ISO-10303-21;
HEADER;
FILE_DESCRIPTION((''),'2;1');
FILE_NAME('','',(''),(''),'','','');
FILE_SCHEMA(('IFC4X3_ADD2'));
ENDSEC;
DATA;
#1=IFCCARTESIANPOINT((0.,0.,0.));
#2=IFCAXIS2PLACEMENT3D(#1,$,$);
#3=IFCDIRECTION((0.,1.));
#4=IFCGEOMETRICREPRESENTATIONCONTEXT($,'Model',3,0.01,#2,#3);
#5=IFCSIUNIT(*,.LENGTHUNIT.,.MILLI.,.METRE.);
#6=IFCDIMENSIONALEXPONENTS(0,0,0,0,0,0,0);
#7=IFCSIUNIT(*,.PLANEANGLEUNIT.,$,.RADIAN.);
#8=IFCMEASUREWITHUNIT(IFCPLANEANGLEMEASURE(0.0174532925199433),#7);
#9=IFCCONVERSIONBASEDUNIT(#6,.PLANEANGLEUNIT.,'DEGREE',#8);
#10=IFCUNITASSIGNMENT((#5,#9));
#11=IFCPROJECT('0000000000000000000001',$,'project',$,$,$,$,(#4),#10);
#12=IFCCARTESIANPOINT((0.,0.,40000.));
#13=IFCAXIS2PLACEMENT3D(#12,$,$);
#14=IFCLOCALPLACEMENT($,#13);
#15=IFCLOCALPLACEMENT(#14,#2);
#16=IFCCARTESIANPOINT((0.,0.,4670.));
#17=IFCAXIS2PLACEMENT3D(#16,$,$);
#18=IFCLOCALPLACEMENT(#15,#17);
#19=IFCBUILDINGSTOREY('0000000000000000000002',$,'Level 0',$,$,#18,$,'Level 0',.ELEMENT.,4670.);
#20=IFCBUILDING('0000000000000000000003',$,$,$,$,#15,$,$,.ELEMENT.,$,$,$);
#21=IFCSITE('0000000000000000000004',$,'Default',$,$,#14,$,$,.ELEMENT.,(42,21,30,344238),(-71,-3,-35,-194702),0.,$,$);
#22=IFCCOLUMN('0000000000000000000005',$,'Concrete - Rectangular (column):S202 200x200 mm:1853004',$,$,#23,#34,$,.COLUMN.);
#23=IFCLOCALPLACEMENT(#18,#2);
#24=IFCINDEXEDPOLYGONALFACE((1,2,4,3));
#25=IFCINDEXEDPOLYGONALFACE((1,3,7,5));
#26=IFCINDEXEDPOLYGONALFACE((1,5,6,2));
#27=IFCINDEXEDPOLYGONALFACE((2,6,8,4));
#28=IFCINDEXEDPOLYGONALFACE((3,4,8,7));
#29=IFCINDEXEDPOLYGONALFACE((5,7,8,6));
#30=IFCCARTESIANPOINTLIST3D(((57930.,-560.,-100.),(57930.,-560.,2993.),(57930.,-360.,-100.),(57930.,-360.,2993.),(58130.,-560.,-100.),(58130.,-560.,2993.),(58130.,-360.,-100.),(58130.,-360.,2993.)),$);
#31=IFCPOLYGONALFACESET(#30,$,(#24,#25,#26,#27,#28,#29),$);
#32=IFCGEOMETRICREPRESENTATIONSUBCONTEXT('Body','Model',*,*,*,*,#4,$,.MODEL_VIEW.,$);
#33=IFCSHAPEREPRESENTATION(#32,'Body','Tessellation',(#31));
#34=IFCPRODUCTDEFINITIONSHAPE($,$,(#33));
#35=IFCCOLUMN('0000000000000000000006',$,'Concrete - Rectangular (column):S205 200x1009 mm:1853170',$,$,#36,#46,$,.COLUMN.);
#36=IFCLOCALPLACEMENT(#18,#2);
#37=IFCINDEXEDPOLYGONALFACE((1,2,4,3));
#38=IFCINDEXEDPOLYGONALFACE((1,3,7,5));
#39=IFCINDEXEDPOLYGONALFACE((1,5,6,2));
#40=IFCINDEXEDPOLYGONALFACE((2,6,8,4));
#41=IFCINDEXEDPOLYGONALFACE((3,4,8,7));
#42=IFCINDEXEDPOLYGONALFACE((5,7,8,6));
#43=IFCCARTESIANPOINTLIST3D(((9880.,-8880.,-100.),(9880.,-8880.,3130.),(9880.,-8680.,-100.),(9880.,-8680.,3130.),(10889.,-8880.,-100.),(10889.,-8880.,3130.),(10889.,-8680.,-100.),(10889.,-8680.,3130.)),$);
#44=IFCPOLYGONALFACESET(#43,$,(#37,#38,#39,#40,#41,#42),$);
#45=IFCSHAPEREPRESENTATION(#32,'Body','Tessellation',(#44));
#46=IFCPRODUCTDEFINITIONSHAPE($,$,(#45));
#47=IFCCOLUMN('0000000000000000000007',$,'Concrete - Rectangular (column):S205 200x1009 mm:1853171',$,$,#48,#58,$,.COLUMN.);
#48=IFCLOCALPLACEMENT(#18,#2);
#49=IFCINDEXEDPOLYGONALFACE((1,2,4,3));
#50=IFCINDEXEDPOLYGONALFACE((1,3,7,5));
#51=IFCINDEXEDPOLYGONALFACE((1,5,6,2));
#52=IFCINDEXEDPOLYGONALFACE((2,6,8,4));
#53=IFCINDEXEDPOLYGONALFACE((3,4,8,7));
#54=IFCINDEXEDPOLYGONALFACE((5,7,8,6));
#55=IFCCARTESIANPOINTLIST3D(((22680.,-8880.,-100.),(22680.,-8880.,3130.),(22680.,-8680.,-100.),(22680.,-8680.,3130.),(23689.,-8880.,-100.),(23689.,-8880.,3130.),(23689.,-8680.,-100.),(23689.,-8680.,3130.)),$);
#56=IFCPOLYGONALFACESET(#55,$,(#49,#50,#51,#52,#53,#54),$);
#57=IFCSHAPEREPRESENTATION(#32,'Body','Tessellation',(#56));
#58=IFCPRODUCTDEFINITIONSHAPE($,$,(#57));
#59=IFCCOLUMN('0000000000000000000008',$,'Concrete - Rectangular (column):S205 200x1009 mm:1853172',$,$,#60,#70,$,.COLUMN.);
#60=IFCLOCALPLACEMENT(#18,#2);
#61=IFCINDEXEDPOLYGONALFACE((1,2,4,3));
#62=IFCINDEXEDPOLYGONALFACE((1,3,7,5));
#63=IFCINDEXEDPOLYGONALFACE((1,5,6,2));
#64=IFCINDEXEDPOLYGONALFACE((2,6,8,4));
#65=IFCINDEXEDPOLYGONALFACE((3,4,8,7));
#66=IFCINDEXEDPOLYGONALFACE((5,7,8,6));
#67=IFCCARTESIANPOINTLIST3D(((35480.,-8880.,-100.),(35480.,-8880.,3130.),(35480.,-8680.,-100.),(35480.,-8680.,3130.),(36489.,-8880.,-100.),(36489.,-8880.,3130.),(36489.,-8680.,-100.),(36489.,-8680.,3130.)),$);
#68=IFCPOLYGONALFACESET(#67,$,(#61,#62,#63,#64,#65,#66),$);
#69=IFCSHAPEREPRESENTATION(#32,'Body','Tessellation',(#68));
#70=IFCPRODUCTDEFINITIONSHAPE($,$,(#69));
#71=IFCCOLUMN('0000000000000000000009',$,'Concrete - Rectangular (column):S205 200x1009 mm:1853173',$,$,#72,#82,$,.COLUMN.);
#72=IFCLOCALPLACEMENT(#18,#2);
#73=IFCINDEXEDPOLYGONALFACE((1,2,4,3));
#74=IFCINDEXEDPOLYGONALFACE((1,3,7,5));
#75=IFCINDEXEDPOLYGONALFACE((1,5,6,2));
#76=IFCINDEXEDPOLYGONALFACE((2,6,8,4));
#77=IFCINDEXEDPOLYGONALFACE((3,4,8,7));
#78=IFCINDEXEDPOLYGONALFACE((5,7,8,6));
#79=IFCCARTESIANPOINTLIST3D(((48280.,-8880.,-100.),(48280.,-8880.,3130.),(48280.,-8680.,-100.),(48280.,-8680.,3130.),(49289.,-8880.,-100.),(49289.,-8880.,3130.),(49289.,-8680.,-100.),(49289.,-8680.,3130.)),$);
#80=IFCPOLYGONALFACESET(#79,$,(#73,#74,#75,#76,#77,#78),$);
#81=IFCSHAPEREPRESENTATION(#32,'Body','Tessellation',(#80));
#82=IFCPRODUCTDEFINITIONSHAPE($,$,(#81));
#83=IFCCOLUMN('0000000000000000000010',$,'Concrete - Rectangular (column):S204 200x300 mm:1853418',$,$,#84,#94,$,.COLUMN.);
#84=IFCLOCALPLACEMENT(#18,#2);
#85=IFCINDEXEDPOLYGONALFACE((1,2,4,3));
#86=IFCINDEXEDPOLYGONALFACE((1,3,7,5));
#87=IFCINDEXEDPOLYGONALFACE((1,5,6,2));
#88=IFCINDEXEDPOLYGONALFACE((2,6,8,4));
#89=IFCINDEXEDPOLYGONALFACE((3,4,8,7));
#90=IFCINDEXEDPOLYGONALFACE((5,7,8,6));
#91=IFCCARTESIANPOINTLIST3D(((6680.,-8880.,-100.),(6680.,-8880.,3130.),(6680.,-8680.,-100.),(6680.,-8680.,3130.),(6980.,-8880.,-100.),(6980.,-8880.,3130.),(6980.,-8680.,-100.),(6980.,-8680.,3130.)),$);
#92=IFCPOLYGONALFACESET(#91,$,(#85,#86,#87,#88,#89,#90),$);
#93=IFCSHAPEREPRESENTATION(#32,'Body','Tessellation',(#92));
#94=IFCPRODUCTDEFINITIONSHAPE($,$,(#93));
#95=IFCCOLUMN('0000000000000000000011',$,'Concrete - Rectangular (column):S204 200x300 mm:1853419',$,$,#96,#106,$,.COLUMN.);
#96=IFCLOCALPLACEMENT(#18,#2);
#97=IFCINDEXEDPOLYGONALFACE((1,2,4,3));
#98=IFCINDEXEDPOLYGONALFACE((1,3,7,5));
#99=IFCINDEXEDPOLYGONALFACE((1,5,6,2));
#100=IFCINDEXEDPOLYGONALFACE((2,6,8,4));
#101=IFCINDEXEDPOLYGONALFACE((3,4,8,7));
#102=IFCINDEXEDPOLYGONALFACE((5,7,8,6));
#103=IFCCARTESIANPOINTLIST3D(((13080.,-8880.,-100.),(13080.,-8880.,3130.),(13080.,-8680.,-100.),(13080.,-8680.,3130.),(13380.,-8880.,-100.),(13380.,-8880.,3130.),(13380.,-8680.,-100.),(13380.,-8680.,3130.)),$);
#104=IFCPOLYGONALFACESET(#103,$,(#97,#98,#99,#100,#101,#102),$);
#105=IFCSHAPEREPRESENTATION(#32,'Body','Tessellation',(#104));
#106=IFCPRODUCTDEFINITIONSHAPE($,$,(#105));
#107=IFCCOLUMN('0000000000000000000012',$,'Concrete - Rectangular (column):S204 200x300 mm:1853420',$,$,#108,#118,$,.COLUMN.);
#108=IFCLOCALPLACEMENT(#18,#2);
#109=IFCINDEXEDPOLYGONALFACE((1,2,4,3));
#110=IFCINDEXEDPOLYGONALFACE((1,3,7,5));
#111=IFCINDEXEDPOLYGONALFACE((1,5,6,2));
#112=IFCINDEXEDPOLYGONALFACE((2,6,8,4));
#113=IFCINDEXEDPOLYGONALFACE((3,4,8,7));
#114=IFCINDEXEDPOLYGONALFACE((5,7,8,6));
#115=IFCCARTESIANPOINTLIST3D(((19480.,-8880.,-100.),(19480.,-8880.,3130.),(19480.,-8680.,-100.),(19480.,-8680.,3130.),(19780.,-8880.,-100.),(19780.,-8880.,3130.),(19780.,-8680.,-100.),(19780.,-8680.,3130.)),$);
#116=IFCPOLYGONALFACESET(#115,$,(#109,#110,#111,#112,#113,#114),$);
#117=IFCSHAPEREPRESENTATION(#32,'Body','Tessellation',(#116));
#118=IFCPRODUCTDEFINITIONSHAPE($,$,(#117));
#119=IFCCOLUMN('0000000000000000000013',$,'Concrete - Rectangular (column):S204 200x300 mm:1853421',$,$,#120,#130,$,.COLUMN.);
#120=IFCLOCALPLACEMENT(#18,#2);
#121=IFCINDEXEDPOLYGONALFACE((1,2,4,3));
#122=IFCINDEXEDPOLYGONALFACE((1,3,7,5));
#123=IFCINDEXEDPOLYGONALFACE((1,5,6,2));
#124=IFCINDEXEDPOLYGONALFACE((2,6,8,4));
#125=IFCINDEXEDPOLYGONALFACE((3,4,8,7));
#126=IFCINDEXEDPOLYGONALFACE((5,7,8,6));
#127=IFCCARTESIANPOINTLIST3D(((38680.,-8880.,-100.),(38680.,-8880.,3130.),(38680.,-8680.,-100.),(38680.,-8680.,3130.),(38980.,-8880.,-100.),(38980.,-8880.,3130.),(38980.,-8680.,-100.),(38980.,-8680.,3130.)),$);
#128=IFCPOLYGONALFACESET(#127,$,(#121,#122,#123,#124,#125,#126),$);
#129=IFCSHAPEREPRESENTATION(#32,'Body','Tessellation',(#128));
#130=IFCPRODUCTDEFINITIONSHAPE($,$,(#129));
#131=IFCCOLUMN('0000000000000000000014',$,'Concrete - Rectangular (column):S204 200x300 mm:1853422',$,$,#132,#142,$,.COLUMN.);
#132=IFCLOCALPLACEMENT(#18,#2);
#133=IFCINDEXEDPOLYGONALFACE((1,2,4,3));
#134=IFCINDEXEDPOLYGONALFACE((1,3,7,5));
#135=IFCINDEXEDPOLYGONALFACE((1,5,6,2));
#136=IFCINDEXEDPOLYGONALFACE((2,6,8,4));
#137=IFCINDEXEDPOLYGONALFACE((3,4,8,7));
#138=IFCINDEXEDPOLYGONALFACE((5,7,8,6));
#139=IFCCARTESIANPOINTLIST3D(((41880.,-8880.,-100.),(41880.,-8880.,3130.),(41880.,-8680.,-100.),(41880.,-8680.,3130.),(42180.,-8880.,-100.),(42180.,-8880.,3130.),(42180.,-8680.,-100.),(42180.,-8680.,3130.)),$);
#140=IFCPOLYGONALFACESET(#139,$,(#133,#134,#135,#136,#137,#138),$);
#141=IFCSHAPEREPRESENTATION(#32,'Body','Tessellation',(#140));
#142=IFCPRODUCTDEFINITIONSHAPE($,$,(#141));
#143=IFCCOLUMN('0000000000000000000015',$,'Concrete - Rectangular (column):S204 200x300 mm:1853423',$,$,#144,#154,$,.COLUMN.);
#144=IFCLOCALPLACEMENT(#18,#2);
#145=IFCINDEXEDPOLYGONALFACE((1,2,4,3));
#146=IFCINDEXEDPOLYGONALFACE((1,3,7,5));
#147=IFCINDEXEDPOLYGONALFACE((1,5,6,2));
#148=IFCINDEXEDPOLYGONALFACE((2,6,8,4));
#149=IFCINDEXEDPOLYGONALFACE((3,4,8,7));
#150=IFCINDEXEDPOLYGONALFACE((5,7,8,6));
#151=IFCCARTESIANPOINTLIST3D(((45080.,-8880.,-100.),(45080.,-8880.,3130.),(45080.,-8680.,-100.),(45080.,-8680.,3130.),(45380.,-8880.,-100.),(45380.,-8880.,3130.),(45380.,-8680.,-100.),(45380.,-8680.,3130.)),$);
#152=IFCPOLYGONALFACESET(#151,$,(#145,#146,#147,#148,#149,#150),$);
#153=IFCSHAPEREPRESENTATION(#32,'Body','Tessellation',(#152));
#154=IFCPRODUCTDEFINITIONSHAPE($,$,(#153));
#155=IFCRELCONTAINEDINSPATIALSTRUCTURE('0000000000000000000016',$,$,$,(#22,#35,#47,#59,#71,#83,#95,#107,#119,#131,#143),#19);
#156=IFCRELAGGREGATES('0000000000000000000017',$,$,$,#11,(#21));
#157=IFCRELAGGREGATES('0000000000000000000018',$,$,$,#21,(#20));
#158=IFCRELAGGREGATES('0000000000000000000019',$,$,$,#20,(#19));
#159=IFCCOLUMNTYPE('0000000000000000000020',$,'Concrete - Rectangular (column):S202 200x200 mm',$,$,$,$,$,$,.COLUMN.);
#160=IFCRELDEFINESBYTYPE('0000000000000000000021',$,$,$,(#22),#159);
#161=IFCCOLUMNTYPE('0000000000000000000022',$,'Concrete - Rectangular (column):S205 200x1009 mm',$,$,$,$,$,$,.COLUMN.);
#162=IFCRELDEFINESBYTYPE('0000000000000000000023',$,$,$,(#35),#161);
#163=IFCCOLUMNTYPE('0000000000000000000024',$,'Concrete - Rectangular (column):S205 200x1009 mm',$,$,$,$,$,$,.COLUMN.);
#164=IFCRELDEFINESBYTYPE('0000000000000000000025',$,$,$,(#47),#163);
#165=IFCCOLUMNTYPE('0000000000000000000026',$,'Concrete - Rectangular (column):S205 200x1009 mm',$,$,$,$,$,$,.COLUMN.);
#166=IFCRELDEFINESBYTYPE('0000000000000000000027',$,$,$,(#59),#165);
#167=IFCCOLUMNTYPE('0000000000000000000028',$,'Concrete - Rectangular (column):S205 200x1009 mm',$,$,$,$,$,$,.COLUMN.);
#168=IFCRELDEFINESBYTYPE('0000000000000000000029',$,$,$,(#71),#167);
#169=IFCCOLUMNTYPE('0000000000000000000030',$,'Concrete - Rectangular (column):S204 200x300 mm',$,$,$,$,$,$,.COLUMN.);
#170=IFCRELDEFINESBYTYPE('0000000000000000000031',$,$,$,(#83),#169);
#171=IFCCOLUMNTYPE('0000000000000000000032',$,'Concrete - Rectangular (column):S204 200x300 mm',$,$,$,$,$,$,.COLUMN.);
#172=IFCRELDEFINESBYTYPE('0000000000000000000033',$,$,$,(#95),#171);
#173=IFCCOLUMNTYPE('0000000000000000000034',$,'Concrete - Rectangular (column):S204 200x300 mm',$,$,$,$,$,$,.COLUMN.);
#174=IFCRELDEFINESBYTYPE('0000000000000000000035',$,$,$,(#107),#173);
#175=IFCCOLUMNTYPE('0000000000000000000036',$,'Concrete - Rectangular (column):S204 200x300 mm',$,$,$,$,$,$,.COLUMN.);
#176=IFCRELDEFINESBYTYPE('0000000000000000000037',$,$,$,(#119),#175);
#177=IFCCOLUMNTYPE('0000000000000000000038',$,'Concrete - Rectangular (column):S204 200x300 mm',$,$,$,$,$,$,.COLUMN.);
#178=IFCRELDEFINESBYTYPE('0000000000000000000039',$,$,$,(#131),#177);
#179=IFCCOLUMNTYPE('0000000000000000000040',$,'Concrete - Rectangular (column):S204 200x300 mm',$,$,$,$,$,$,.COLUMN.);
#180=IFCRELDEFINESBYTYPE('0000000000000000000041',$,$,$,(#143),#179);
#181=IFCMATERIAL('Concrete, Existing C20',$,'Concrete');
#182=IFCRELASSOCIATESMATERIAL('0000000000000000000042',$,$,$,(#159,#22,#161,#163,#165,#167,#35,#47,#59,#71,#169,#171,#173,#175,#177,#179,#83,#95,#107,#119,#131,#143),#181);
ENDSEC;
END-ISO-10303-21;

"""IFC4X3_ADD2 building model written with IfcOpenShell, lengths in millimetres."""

from ifc_helpers import new_model, entity, si_unit, converted_unit, direction, frame, frame_2d, origin, origin_2d_with_axis, place, context, subcontext, project, spatial, rectangle, extrude, source, transform, mapped, material, material_profile, profile_set, profile_usage, type_object, type_shapes, element, save


model = new_model("IFC4X3_ADD2")

# Units and contexts
model_context = context("Model", 3, precision=0.01, world=origin(), true_north=direction((0.0, 1.0)))
body_context = subcontext(model_context, "Body", "Model", "MODEL_VIEW")
ifc_project = project(units=[si_unit("LENGTHUNIT", "METRE", prefix="MILLI"), converted_unit("PLANEANGLEUNIT", "DEGREE", entity("IfcPlaneAngleMeasure", 0.0174532925199433), si_unit("PLANEANGLEUNIT", "RADIAN"), dimensions=[0, 0, 0, 0, 0, 0, 0])], contexts=[model_context])

# Site, building, storey
site_placement = place(None, frame((0.0, 0.0, 40000.0)))
site = spatial("IfcSite", under=ifc_project, at=site_placement, Name="Default", CompositionType="ELEMENT", RefLatitude=(42, 21, 30, 344238), RefLongitude=(-71, -3, -35, -194702), RefElevation=0.0)
building_placement = place(site_placement, origin())
building = spatial("IfcBuilding", under=site, at=building_placement, CompositionType="ELEMENT")
storey_placement = place(building_placement, frame((0.0, 0.0, 4670.0)))
storey = spatial("IfcBuildingStorey", under=building, at=storey_placement, Name="Level 0", LongName="Level 0", CompositionType="ELEMENT", Elevation=4670.0)

# Columns
ifc_material = material(Name="Concrete, Existing C20", Category="Concrete")
ifc_material_profile_1 = material_profile(ifc_material, rectangle(XDim=200.0, YDim=200.0, at=frame_2d((0.0, 0.0), x_axis=(1.0, 0.0))), Name="S202 200x200 mm")
ifc_profile_set_1 = profile_set([ifc_material_profile_1], Name="S202 200x200 mm")
ifc_profile_usage_1 = profile_usage(ifc_profile_set_1)
column_type_1 = type_object("IfcColumnType", Name="Concrete - Rectangular (column):S202 200x200 mm", PredefinedType="COLUMN", material=ifc_profile_set_1)
shared_shape_1 = source(origin(), body_context, "Body", "SweptSolid", [
    extrude(rectangle(XDim=200.0, YDim=200.0, at=frame_2d((0.0, 0.0), x_axis=(1.0, 0.0))), frame((58030.0, -460.0, 4570.0), z_axis=(0.0, 0.0, 1.0), x_axis=(0.0, 1.0, 0.0)), (0.0, 0.0, 1.0), 3093.0),
])
type_shapes(column_type_1, [shared_shape_1])
column_1_placement = place(storey_placement, frame((0.0, 0.0, -4670.0)))
element("IfcColumn", 1, at=column_1_placement, inside=storey, type_object=column_type_1, material=ifc_profile_usage_1, Name="Concrete - Rectangular (column):S202 200x200 mm:1853004", PredefinedType="COLUMN", context=body_context, shape_type="MappedRepresentation", body=[
    mapped(shared_shape_1, transform((0.0, 0.0, 0.0), scale=1.0)),
])
ifc_material_profile_2 = material_profile(ifc_material, rectangle(XDim=200.0, YDim=1009.0, at=origin_2d_with_axis()), Name="S205 200x1009 mm")
ifc_profile_set_2 = profile_set([ifc_material_profile_2], Name="S205 200x1009 mm")
ifc_profile_usage_2 = profile_usage(ifc_profile_set_2)
column_type_2 = type_object("IfcColumnType", Name="Concrete - Rectangular (column):S205 200x1009 mm", PredefinedType="COLUMN", material=ifc_profile_set_2)
shared_shape_2 = source(origin(), body_context, "Body", "SweptSolid", [
    extrude(rectangle(XDim=200.0, YDim=1009.0, at=origin_2d_with_axis()), frame((10384.5, -8780.0, 4570.0), z_axis=(0.0, 0.0, 1.0), x_axis=(0.0, 1.0, 0.0)), (0.0, 0.0, 1.0), 3230.0),
])
type_shapes(column_type_2, [shared_shape_2])
column_2_placement = place(storey_placement, frame((0.0, 0.0, -4670.0)))
element("IfcColumn", 2, at=column_2_placement, inside=storey, type_object=column_type_2, material=ifc_profile_usage_2, Name="Concrete - Rectangular (column):S205 200x1009 mm:1853170", PredefinedType="COLUMN", context=body_context, shape_type="MappedRepresentation", body=[
    mapped(shared_shape_2, transform((0.0, 0.0, 0.0), scale=1.0)),
])
column_type_3 = type_object("IfcColumnType", Name="Concrete - Rectangular (column):S205 200x1009 mm", PredefinedType="COLUMN", material=ifc_profile_set_2)
shared_shape_3 = source(origin(), body_context, "Body", "SweptSolid", [
    extrude(rectangle(XDim=200.0, YDim=1009.0, at=frame_2d((0.0, 0.0), x_axis=(1.0, 0.0))), frame((23184.5, -8780.0, 4570.0), z_axis=(0.0, 0.0, 1.0), x_axis=(0.0, 1.0, 0.0)), (0.0, 0.0, 1.0), 3230.0),
])
type_shapes(column_type_3, [shared_shape_3])
column_3_placement = place(storey_placement, frame((0.0, 0.0, -4670.0)))
element("IfcColumn", 3, at=column_3_placement, inside=storey, type_object=column_type_3, material=ifc_profile_usage_2, Name="Concrete - Rectangular (column):S205 200x1009 mm:1853171", PredefinedType="COLUMN", context=body_context, shape_type="MappedRepresentation", body=[
    mapped(shared_shape_3, transform((0.0, 0.0, 0.0), scale=1.0)),
])
column_type_4 = type_object("IfcColumnType", Name="Concrete - Rectangular (column):S205 200x1009 mm", PredefinedType="COLUMN", material=ifc_profile_set_2)
shared_shape_4 = source(origin(), body_context, "Body", "SweptSolid", [
    extrude(rectangle(XDim=200.0, YDim=1009.0, at=frame_2d((0.0, 0.0), x_axis=(1.0, 0.0))), frame((35984.5, -8780.0, 4570.0), z_axis=(0.0, 0.0, 1.0), x_axis=(0.0, 1.0, 0.0)), (0.0, 0.0, 1.0), 3230.0),
])
type_shapes(column_type_4, [shared_shape_4])
column_4_placement = place(storey_placement, frame((0.0, 0.0, -4670.0)))
element("IfcColumn", 4, at=column_4_placement, inside=storey, type_object=column_type_4, material=ifc_profile_usage_2, Name="Concrete - Rectangular (column):S205 200x1009 mm:1853172", PredefinedType="COLUMN", context=body_context, shape_type="MappedRepresentation", body=[
    mapped(shared_shape_4, transform((0.0, 0.0, 0.0), scale=1.0)),
])
column_type_5 = type_object("IfcColumnType", Name="Concrete - Rectangular (column):S205 200x1009 mm", PredefinedType="COLUMN", material=ifc_profile_set_2)
shared_shape_5 = source(origin(), body_context, "Body", "SweptSolid", [
    extrude(rectangle(XDim=200.0, YDim=1009.0, at=origin_2d_with_axis()), frame((48784.5, -8780.0, 4570.0), z_axis=(0.0, 0.0, 1.0), x_axis=(0.0, 1.0, 0.0)), (0.0, 0.0, 1.0), 3230.0),
])
type_shapes(column_type_5, [shared_shape_5])
column_5_placement = place(storey_placement, frame((0.0, 0.0, -4670.0)))
element("IfcColumn", 5, at=column_5_placement, inside=storey, type_object=column_type_5, material=ifc_profile_usage_2, Name="Concrete - Rectangular (column):S205 200x1009 mm:1853173", PredefinedType="COLUMN", context=body_context, shape_type="MappedRepresentation", body=[
    mapped(shared_shape_5, transform((0.0, 0.0, 0.0), scale=1.0)),
])
ifc_material_profile_3 = material_profile(ifc_material, rectangle(XDim=200.0, YDim=300.0, at=frame_2d((0.0, 0.0), x_axis=(1.0, 0.0))), Name="S204 200x300 mm")
ifc_profile_set_3 = profile_set([ifc_material_profile_3], Name="S204 200x300 mm")
ifc_profile_usage_3 = profile_usage(ifc_profile_set_3)
column_type_6 = type_object("IfcColumnType", Name="Concrete - Rectangular (column):S204 200x300 mm", PredefinedType="COLUMN", material=ifc_profile_set_3)
shared_shape_6 = source(origin(), body_context, "Body", "SweptSolid", [
    extrude(rectangle(XDim=200.0, YDim=300.0, at=frame_2d((0.0, 0.0), x_axis=(1.0, 0.0))), frame((6830.0, -8780.0, 4570.0), z_axis=(0.0, 0.0, 1.0), x_axis=(0.0, 1.0, 0.0)), (0.0, 0.0, 1.0), 3230.0),
])
type_shapes(column_type_6, [shared_shape_6])
column_6_placement = place(storey_placement, frame((0.0, 0.0, -4670.0)))
element("IfcColumn", 6, at=column_6_placement, inside=storey, type_object=column_type_6, material=ifc_profile_usage_3, Name="Concrete - Rectangular (column):S204 200x300 mm:1853418", PredefinedType="COLUMN", context=body_context, shape_type="MappedRepresentation", body=[
    mapped(shared_shape_6, transform((0.0, 0.0, 0.0), scale=1.0)),
])
column_type_7 = type_object("IfcColumnType", Name="Concrete - Rectangular (column):S204 200x300 mm", PredefinedType="COLUMN", material=ifc_profile_set_3)
shared_shape_7 = source(origin(), body_context, "Body", "SweptSolid", [
    extrude(rectangle(XDim=200.0, YDim=300.0, at=frame_2d((0.0, 0.0), x_axis=(1.0, 0.0))), frame((13230.0, -8780.0, 4570.0), z_axis=(0.0, 0.0, 1.0), x_axis=(0.0, 1.0, 0.0)), (0.0, 0.0, 1.0), 3230.0),
])
type_shapes(column_type_7, [shared_shape_7])
column_7_placement = place(storey_placement, frame((0.0, 0.0, -4670.0)))
element("IfcColumn", 7, at=column_7_placement, inside=storey, type_object=column_type_7, material=ifc_profile_usage_3, Name="Concrete - Rectangular (column):S204 200x300 mm:1853419", PredefinedType="COLUMN", context=body_context, shape_type="MappedRepresentation", body=[
    mapped(shared_shape_7, transform((0.0, 0.0, 0.0), scale=1.0)),
])
column_type_8 = type_object("IfcColumnType", Name="Concrete - Rectangular (column):S204 200x300 mm", PredefinedType="COLUMN", material=ifc_profile_set_3)
shared_shape_8 = source(origin(), body_context, "Body", "SweptSolid", [
    extrude(rectangle(XDim=200.0, YDim=300.0, at=frame_2d((0.0, 0.0), x_axis=(1.0, 0.0))), frame((19630.0, -8780.0, 4570.0), z_axis=(0.0, 0.0, 1.0), x_axis=(0.0, 1.0, 0.0)), (0.0, 0.0, 1.0), 3230.0),
])
type_shapes(column_type_8, [shared_shape_8])
column_8_placement = place(storey_placement, frame((0.0, 0.0, -4670.0)))
element("IfcColumn", 8, at=column_8_placement, inside=storey, type_object=column_type_8, material=ifc_profile_usage_3, Name="Concrete - Rectangular (column):S204 200x300 mm:1853420", PredefinedType="COLUMN", context=body_context, shape_type="MappedRepresentation", body=[
    mapped(shared_shape_8, transform((0.0, 0.0, 0.0), scale=1.0)),
])
column_type_9 = type_object("IfcColumnType", Name="Concrete - Rectangular (column):S204 200x300 mm", PredefinedType="COLUMN", material=ifc_profile_set_3)
shared_shape_9 = source(origin(), body_context, "Body", "SweptSolid", [
    extrude(rectangle(XDim=200.0, YDim=300.0, at=frame_2d((0.0, 0.0), x_axis=(1.0, 0.0))), frame((38830.0, -8780.0, 4570.0), z_axis=(0.0, 0.0, 1.0), x_axis=(0.0, 1.0, 0.0)), (0.0, 0.0, 1.0), 3230.0),
])
type_shapes(column_type_9, [shared_shape_9])
column_9_placement = place(storey_placement, frame((0.0, 0.0, -4670.0)))
element("IfcColumn", 9, at=column_9_placement, inside=storey, type_object=column_type_9, material=ifc_profile_usage_3, Name="Concrete - Rectangular (column):S204 200x300 mm:1853421", PredefinedType="COLUMN", context=body_context, shape_type="MappedRepresentation", body=[
    mapped(shared_shape_9, transform((0.0, 0.0, 0.0), scale=1.0)),
])
column_type_10 = type_object("IfcColumnType", Name="Concrete - Rectangular (column):S204 200x300 mm", PredefinedType="COLUMN", material=ifc_profile_set_3)
shared_shape_10 = source(origin(), body_context, "Body", "SweptSolid", [
    extrude(rectangle(XDim=200.0, YDim=300.0, at=frame_2d((0.0, 0.0), x_axis=(1.0, 0.0))), frame((42030.0, -8780.0, 4570.0), z_axis=(0.0, 0.0, 1.0), x_axis=(0.0, 1.0, 0.0)), (0.0, 0.0, 1.0), 3230.0),
])
type_shapes(column_type_10, [shared_shape_10])
column_10_placement = place(storey_placement, frame((0.0, 0.0, -4670.0)))
element("IfcColumn", 10, at=column_10_placement, inside=storey, type_object=column_type_10, material=ifc_profile_usage_3, Name="Concrete - Rectangular (column):S204 200x300 mm:1853422", PredefinedType="COLUMN", context=body_context, shape_type="MappedRepresentation", body=[
    mapped(shared_shape_10, transform((0.0, 0.0, 0.0), scale=1.0)),
])
column_type_11 = type_object("IfcColumnType", Name="Concrete - Rectangular (column):S204 200x300 mm", PredefinedType="COLUMN", material=ifc_profile_set_3)
shared_shape_11 = source(origin(), body_context, "Body", "SweptSolid", [
    extrude(rectangle(XDim=200.0, YDim=300.0, at=frame_2d((0.0, 0.0), x_axis=(1.0, 0.0))), frame((45230.0, -8780.0, 4570.0), z_axis=(0.0, 0.0, 1.0), x_axis=(0.0, 1.0, 0.0)), (0.0, 0.0, 1.0), 3230.0),
])
type_shapes(column_type_11, [shared_shape_11])
column_11_placement = place(storey_placement, frame((0.0, 0.0, -4670.0)))
element("IfcColumn", 11, at=column_11_placement, inside=storey, type_object=column_type_11, material=ifc_profile_usage_3, Name="Concrete - Rectangular (column):S204 200x300 mm:1853423", PredefinedType="COLUMN", context=body_context, shape_type="MappedRepresentation", body=[
    mapped(shared_shape_11, transform((0.0, 0.0, 0.0), scale=1.0)),
])

save(model, "model.ifc")
